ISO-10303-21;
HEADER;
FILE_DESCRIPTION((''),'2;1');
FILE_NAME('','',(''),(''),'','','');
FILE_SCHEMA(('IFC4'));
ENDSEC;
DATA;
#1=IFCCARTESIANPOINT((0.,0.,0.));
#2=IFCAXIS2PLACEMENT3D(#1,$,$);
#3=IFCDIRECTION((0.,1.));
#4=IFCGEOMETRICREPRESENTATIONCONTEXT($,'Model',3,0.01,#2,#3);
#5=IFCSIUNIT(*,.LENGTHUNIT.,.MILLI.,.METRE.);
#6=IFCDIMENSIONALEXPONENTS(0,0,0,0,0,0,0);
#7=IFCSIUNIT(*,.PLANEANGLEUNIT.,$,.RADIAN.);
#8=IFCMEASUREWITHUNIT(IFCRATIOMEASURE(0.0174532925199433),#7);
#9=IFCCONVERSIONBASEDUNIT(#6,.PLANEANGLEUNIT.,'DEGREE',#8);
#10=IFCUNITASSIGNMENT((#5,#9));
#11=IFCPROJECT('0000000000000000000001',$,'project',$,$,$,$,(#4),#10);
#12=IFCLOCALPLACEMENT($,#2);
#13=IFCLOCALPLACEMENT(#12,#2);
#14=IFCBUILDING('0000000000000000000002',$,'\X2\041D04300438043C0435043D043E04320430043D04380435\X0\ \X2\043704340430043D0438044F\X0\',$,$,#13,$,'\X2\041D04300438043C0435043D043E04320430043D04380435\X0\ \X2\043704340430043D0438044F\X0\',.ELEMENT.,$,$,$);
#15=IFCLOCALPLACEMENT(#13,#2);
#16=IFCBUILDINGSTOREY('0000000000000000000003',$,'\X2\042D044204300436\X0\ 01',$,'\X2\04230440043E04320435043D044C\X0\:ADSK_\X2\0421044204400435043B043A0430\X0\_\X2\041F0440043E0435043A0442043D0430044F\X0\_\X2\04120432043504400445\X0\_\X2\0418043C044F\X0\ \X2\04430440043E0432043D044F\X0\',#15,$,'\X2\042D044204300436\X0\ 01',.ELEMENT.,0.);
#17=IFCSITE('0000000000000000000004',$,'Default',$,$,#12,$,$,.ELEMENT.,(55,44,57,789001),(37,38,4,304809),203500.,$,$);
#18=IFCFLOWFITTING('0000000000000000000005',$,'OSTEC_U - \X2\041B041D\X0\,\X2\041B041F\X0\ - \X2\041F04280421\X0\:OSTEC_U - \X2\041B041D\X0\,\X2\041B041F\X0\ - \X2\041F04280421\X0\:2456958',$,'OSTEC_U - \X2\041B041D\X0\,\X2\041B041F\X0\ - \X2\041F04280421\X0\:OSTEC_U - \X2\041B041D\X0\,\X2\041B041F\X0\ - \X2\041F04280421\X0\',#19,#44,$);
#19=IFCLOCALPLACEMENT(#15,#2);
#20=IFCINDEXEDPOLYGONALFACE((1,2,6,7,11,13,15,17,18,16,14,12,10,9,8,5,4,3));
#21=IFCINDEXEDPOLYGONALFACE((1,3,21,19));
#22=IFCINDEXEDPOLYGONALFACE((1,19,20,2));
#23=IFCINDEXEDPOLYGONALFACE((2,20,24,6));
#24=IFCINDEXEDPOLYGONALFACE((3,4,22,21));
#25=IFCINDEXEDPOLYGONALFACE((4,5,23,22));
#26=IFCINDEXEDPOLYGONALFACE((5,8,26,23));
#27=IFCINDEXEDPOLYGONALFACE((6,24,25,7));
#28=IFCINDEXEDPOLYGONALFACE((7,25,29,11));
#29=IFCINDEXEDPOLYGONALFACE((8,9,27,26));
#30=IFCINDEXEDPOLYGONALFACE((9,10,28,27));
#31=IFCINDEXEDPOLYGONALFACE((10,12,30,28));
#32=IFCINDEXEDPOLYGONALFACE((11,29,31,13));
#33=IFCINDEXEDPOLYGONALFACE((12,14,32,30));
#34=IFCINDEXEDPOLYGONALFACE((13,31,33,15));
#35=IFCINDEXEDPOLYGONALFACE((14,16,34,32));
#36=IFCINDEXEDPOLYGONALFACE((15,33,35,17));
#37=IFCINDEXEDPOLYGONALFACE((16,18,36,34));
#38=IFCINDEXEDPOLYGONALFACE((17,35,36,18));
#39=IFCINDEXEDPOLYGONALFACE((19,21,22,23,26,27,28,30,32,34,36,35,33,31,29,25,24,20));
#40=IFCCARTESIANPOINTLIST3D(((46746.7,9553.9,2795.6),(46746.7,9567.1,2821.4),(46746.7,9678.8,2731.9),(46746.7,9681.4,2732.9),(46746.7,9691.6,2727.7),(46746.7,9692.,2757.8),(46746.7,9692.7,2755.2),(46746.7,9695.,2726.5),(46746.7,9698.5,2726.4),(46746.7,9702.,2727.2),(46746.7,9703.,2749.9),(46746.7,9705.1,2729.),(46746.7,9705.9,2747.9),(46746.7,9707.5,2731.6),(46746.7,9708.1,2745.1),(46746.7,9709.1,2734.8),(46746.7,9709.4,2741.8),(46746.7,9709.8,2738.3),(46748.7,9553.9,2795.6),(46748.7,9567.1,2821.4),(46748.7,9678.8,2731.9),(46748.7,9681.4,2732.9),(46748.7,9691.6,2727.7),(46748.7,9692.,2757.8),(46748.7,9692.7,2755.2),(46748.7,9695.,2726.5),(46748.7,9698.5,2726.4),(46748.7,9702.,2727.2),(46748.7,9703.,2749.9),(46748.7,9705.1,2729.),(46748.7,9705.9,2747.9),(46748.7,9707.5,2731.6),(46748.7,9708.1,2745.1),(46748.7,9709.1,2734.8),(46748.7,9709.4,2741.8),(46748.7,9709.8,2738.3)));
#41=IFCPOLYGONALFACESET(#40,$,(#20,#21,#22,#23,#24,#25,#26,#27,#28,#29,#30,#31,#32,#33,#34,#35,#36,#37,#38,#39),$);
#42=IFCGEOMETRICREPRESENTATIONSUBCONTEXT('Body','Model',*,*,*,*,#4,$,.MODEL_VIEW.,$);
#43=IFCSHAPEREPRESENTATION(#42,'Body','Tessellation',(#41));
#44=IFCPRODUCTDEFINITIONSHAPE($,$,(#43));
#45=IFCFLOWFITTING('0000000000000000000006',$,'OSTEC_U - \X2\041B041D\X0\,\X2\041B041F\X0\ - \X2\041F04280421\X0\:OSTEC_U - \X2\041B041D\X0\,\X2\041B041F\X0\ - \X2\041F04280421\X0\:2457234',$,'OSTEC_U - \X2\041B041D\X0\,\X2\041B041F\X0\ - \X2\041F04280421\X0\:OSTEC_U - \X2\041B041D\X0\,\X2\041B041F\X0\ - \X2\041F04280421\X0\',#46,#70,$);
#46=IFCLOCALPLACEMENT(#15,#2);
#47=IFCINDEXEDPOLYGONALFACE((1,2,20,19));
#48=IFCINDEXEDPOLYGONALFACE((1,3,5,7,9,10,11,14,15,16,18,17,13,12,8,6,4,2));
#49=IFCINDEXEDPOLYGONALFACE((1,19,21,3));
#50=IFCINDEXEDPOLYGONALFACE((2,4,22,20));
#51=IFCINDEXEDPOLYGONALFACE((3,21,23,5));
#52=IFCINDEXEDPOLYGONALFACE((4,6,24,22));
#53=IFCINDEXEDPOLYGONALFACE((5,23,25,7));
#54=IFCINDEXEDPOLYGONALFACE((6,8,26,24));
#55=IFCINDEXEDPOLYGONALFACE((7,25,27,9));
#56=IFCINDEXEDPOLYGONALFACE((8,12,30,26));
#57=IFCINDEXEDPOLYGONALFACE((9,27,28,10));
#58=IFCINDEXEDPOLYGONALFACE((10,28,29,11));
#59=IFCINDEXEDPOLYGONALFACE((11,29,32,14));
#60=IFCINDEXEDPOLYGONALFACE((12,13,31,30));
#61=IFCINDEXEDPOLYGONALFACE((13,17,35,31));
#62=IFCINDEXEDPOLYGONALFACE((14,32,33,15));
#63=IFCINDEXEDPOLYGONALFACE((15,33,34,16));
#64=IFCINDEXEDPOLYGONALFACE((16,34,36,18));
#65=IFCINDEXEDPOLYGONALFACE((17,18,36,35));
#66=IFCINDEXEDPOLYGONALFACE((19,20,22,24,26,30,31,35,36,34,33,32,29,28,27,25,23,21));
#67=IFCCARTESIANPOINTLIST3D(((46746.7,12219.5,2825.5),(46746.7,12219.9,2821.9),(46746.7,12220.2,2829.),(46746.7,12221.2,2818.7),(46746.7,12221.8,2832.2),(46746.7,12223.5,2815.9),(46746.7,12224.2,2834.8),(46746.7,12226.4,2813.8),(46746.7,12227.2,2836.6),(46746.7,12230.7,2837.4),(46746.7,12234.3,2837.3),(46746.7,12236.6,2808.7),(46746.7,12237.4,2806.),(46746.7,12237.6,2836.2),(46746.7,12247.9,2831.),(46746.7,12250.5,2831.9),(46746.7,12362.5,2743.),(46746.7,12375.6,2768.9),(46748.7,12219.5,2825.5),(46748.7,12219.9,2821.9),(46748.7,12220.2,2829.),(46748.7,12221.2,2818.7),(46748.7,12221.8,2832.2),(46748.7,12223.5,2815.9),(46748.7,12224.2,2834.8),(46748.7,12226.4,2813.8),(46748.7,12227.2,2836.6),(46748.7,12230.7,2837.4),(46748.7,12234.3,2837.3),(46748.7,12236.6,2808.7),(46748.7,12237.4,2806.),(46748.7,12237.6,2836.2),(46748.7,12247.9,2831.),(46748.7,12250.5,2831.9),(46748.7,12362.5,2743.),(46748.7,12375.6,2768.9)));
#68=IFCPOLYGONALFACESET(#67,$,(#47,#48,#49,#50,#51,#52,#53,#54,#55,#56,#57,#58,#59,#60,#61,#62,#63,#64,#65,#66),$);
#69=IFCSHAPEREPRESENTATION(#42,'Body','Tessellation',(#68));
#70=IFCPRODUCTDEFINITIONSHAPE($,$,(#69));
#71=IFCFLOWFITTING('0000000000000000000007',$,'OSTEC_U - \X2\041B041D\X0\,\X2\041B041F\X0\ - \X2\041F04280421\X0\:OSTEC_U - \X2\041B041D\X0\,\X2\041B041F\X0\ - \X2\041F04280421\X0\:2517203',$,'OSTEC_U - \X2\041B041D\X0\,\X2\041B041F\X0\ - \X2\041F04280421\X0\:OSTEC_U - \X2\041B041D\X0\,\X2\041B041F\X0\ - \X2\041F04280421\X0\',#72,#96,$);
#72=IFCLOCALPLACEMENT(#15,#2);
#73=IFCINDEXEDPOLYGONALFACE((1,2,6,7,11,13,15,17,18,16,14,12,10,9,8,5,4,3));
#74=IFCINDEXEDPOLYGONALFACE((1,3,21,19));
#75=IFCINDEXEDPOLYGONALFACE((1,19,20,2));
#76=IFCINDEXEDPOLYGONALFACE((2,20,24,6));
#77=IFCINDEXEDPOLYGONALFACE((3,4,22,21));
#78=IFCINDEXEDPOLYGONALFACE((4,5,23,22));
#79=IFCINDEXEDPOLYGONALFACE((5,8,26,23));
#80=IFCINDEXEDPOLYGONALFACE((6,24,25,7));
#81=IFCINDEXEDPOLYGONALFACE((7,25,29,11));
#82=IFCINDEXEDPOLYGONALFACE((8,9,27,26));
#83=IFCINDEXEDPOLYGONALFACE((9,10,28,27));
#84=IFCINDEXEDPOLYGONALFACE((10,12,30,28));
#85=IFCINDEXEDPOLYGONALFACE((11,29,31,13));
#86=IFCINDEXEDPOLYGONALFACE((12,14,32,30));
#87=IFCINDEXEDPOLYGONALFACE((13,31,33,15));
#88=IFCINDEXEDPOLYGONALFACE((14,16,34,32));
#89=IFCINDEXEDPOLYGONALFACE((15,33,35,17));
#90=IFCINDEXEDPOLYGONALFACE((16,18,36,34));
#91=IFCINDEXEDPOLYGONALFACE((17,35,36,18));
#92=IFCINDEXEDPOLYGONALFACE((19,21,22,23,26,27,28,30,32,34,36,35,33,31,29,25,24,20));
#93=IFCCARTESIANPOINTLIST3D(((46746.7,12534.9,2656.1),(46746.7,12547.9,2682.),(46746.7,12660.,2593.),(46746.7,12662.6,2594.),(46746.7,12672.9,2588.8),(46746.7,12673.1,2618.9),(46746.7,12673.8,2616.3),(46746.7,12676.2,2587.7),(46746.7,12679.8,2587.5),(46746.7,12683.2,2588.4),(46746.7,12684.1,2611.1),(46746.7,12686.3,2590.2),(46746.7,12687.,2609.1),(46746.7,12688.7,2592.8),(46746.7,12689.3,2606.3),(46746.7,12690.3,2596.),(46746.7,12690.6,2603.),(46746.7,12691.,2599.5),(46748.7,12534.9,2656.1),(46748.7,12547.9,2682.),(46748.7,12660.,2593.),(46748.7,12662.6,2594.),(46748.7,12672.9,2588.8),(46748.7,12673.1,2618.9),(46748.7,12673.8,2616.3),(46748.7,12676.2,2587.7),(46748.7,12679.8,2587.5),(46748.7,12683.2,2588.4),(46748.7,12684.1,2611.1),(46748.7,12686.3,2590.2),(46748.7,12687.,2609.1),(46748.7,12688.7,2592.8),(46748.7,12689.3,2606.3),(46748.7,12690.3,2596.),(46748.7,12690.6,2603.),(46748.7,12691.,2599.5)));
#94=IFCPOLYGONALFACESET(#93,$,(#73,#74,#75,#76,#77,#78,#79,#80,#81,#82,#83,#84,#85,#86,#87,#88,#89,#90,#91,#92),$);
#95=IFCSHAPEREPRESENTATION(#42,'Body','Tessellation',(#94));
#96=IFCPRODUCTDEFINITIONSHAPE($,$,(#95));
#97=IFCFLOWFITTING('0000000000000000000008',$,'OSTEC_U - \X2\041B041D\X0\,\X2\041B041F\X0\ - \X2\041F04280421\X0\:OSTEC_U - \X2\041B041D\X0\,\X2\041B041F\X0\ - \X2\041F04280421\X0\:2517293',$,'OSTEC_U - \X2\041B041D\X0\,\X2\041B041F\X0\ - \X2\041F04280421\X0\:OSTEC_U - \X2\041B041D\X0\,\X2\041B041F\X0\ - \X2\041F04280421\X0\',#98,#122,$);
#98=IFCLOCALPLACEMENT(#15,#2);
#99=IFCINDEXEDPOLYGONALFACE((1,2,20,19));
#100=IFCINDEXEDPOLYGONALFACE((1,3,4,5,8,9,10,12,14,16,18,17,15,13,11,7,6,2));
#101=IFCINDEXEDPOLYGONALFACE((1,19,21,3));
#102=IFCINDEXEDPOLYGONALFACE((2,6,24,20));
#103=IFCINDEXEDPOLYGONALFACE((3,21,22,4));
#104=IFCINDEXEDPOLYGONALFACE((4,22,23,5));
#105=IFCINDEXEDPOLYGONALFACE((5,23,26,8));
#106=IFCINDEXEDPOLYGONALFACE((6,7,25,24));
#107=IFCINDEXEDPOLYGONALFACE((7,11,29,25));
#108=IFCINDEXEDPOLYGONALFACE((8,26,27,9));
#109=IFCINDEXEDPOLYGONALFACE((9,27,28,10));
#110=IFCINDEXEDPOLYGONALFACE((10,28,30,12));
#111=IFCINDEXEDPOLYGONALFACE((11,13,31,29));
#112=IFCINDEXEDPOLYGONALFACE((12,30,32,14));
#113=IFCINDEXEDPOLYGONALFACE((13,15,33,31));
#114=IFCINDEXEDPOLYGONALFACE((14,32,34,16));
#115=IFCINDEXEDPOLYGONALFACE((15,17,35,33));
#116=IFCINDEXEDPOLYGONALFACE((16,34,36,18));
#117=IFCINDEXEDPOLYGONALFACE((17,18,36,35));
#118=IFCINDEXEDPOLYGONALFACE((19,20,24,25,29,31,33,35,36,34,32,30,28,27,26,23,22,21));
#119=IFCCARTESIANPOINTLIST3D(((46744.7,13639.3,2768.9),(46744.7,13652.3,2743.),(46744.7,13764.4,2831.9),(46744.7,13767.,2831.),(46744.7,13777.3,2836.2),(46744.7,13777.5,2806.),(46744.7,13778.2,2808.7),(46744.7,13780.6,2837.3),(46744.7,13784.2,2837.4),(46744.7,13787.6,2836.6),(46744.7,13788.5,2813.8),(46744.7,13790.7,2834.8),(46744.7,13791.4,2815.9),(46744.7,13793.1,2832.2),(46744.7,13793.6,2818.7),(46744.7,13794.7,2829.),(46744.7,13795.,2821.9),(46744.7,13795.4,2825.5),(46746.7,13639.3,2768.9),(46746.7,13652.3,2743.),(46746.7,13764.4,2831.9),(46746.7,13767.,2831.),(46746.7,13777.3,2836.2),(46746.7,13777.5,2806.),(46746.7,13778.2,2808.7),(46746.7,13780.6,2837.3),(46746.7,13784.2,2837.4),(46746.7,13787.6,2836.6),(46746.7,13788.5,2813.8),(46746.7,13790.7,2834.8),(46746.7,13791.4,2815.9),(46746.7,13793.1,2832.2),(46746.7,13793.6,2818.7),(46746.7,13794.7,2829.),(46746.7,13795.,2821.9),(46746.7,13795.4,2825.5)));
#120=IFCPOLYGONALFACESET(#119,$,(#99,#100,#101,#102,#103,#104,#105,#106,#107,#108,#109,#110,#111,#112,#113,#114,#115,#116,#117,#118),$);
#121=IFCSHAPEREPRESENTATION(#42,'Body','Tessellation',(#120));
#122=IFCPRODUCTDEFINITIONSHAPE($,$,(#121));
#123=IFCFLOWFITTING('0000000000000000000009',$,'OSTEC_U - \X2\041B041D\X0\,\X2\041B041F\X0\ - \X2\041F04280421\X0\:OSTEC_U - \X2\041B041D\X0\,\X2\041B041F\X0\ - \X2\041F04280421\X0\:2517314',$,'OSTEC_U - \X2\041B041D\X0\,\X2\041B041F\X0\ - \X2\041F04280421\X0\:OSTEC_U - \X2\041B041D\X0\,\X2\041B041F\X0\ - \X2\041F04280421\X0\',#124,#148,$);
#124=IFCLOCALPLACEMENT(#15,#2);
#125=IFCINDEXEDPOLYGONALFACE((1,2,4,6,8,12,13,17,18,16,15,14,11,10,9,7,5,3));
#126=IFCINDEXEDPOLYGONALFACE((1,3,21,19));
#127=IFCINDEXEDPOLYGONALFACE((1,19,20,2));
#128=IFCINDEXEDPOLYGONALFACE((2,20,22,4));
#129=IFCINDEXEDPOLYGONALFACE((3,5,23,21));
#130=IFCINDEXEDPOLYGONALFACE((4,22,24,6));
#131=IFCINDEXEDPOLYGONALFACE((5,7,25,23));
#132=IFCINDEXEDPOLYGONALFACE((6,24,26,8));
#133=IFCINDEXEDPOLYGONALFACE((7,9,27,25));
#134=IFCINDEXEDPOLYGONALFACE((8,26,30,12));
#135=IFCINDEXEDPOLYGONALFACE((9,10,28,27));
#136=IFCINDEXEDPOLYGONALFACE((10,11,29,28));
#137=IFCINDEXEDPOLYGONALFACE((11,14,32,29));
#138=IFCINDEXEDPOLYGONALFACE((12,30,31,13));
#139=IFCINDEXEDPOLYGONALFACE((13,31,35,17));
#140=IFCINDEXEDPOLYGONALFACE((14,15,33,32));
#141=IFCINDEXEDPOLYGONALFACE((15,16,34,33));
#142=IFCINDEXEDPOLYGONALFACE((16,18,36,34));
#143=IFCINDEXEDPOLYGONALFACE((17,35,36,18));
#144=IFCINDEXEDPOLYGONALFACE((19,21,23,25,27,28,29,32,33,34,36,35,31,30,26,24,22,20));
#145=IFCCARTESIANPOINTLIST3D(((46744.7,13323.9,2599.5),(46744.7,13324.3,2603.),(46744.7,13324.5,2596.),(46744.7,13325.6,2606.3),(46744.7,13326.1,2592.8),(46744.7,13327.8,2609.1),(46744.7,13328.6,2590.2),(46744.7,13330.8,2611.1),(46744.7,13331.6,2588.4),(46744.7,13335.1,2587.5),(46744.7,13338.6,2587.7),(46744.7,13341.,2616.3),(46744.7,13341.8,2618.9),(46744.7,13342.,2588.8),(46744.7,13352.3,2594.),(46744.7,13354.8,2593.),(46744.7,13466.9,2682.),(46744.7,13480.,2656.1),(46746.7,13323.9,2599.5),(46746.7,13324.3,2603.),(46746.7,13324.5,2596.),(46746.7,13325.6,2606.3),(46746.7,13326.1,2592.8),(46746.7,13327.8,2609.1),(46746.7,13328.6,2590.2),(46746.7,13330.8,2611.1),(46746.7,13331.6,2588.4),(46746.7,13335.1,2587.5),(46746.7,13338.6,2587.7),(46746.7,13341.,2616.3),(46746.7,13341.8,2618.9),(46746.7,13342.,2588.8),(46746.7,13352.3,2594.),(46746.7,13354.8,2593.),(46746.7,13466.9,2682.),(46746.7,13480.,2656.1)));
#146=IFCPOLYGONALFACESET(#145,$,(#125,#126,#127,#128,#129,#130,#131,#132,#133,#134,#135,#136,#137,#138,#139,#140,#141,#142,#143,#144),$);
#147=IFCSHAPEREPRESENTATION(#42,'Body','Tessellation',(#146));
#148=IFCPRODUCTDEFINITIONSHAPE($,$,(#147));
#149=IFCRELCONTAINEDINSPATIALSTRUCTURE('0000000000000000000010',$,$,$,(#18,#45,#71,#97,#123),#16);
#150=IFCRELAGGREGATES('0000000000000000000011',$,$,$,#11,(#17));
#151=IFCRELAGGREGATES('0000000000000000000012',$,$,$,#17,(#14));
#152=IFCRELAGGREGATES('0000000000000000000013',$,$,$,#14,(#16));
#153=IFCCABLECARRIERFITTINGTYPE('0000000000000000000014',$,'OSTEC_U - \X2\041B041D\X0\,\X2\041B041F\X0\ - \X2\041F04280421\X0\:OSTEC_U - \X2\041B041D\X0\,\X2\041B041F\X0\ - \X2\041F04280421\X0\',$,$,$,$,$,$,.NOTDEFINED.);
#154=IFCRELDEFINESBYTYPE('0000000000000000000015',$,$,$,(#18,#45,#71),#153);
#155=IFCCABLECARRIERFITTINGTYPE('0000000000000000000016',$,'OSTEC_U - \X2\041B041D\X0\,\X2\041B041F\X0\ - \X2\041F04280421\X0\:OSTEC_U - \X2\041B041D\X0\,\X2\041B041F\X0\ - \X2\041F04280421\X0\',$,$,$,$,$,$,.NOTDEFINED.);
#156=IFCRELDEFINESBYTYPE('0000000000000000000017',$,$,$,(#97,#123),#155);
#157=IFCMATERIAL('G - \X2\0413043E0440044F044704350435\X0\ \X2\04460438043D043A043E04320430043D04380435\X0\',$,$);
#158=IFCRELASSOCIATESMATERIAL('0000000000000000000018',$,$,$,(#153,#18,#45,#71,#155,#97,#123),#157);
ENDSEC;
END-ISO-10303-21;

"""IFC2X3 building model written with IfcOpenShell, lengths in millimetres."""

from ifc_helpers import new_model, entity, si_unit, converted_unit, direction, frame, frame_2d, origin, place, context, subcontext, project, spatial, polyline, circle_curve, parameter, trimmed, segment, composite_curve, outline, extrude, source, transform, mapped, material, type_object, type_shapes, element, save


model = new_model("IFC2X3")

# Units and contexts
model_context = context("Model", 3, precision=0.01, world=origin(), true_north=direction((0.0, 1.0)))
body_context = subcontext(model_context, "Body", "Model", "MODEL_VIEW")
ifc_project = project(units=[si_unit("LENGTHUNIT", "METRE", prefix="MILLI"), converted_unit("PLANEANGLEUNIT", "DEGREE", entity("IfcRatioMeasure", 0.0174532925199433), si_unit("PLANEANGLEUNIT", "RADIAN"), dimensions=[0, 0, 0, 0, 0, 0, 0])], contexts=[model_context])

# Site, building, storey
site_placement = place(None, origin())
site = spatial("IfcSite", under=ifc_project, at=site_placement, Name="Default", CompositionType="ELEMENT", RefLatitude=(55, 44, 57, 789001), RefLongitude=(37, 38, 4, 304809), RefElevation=203500.0)
building_placement = place(site_placement, origin())
building = spatial("IfcBuilding", under=site, at=building_placement, Name="Наименование здания", LongName="Наименование здания", CompositionType="ELEMENT")
storey_placement = place(building_placement, origin())
storey = spatial("IfcBuildingStorey", under=building, at=storey_placement, Name="Этаж 01", ObjectType="Уровень:ADSK_Стрелка_Проектная_Вверх_Имя уровня", LongName="Этаж 01", CompositionType="ELEMENT", Elevation=0.0)

# Flow fittings
ifc_material_1 = material(Name="G - Горячее цинкование")
shared_shape_1 = source(origin(), body_context, "Body", "SweptSolid", [
    extrude(outline(composite_curve([segment(trimmed(circle_curve(frame_2d((-44.6, 0.0), x_axis=(1.0, 0.0)), 12.5), [parameter(90.0)], [parameter(270.0)], True, "PARAMETER"), True, "CONTINUOUS"), segment(polyline([(-44.6, -12.5), (-33.1, -12.5)]), True, "CONTINUOUS"), segment(polyline([(-33.1, -12.5), (-31.2, -14.5)]), True, "CONTINUOUS"), segment(polyline([(-31.2, -14.5), (108.9, -14.5)]), True, "CONTINUOUS"), segment(polyline([(108.9, -14.5), (108.9, 14.5)]), True, "CONTINUOUS"), segment(polyline([(108.9, 14.5), (-31.2, 14.5)]), True, "CONTINUOUS"), segment(polyline([(-31.2, 14.5), (-33.1, 12.5)]), True, "CONTINUOUS"), segment(polyline([(-33.1, 12.5), (-44.6, 12.5)]), True, "CONTINUOUS")], self_intersect=False)), frame((44.6, 0.0, 0.0), z_axis=(0.0, 0.0, -1.0), x_axis=(1.0, 0.0, 0.0)), (0.0, 0.0, -1.0), 2.0),
])
cable_carrier_fitting_type_1 = type_object("IfcCableCarrierFittingType", Name="OSTEC_U - ЛН,ЛП - ПШС:OSTEC_U - ЛН,ЛП - ПШС", PredefinedType="NOTDEFINED", material=ifc_material_1)
type_shapes(cable_carrier_fitting_type_1, [shared_shape_1])
for number, where, z_axis, x_axis, name in (
    (1, (46748.7, 9697.3, 2738.8), (-1.0, 0.0, 0.0), (0.0, -0.891007, 0.45399), "OSTEC_U - ЛН,ЛП - ПШС:OSTEC_U - ЛН,ЛП - ПШС:2456958"),
    (2, (46748.7, 12232.0, 2825.0), (-1.0, 0.0, 0.0), (0.0, 0.892981, -0.450095), "OSTEC_U - ЛН,ЛП - ПШС:OSTEC_U - ЛН,ЛП - ПШС:2457234"),
):
    element("IfcFlowFitting", number, at=place(storey_placement, frame(where, z_axis=z_axis, x_axis=x_axis)), inside=storey, type_object=cable_carrier_fitting_type_1, material=ifc_material_1, Name=name, ObjectType="OSTEC_U - ЛН,ЛП - ПШС:OSTEC_U - ЛН,ЛП - ПШС", context=body_context, shape_type="MappedRepresentation", body=[
        mapped(shared_shape_1, transform((0.0, 0.0, 0.0), scale=1.0)),
    ])
for number, where, z_axis, x_axis, name in (
    (3, (46748.7, 12678.5, 2599.9), (-1.0, 0.0, 0.0), (0.0, -0.892981, 0.450095), "OSTEC_U - ЛН,ЛП - ПШС:OSTEC_U - ЛН,ЛП - ПШС:2517203"),
):
    element("IfcFlowFitting", number, at=place(storey_placement, frame(where, z_axis=z_axis, x_axis=x_axis)), inside=storey, type_object=cable_carrier_fitting_type_1, material=ifc_material_1, Name=name, ObjectType="OSTEC_U - ЛН,ЛП - ПШС:OSTEC_U - ЛН,ЛП - ПШС", context=body_context, shape_type="MappedRepresentation", body=[
        mapped(shared_shape_1, transform((0.0, 0.0, 0.0), scale=1.0)),
    ])
cable_carrier_fitting_type_2 = type_object("IfcCableCarrierFittingType", Name="OSTEC_U - ЛН,ЛП - ПШС:OSTEC_U - ЛН,ЛП - ПШС", PredefinedType="NOTDEFINED", material=ifc_material_1)
shared_shape_2 = source(origin(), body_context, "Body", "SweptSolid", [
    extrude(outline(composite_curve([segment(trimmed(circle_curve(frame_2d((-44.6, 0.0), x_axis=(1.0, 0.0)), 12.5), [parameter(90.0)], [parameter(270.0)], True, "PARAMETER"), True, "CONTINUOUS"), segment(polyline([(-44.6, -12.5), (-33.1, -12.5)]), True, "CONTINUOUS"), segment(polyline([(-33.1, -12.5), (-31.2, -14.5)]), True, "CONTINUOUS"), segment(polyline([(-31.2, -14.5), (108.9, -14.5)]), True, "CONTINUOUS"), segment(polyline([(108.9, -14.5), (108.9, 14.5)]), True, "CONTINUOUS"), segment(polyline([(108.9, 14.5), (-31.2, 14.5)]), True, "CONTINUOUS"), segment(polyline([(-31.2, 14.5), (-33.1, 12.5)]), True, "CONTINUOUS"), segment(polyline([(-33.1, 12.5), (-44.6, 12.5)]), True, "CONTINUOUS")], self_intersect=False)), frame((44.6, 0.0, 0.0)), (0.0, 0.0, 1.0), 2.0),
])
type_shapes(cable_carrier_fitting_type_2, [shared_shape_2])
for number, where, z_axis, x_axis, name in (
    (4, (46746.7, 13782.9, 2825.0), (-1.0, 0.0, 0.0), (0.0, -0.892981, -0.450095), "OSTEC_U - ЛН,ЛП - ПШС:OSTEC_U - ЛН,ЛП - ПШС:2517293"),
    (5, (46746.7, 13336.4, 2599.9), (-1.0, 0.0, 0.0), (0.0, 0.892981, 0.450095), "OSTEC_U - ЛН,ЛП - ПШС:OSTEC_U - ЛН,ЛП - ПШС:2517314"),
):
    element("IfcFlowFitting", number, at=place(storey_placement, frame(where, z_axis=z_axis, x_axis=x_axis)), inside=storey, type_object=cable_carrier_fitting_type_2, material=ifc_material_1, Name=name, ObjectType="OSTEC_U - ЛН,ЛП - ПШС:OSTEC_U - ЛН,ЛП - ПШС", context=body_context, shape_type="MappedRepresentation", body=[
        mapped(shared_shape_2, transform((0.0, 0.0, 0.0), scale=1.0)),
    ])

save(model, "model.ifc")
